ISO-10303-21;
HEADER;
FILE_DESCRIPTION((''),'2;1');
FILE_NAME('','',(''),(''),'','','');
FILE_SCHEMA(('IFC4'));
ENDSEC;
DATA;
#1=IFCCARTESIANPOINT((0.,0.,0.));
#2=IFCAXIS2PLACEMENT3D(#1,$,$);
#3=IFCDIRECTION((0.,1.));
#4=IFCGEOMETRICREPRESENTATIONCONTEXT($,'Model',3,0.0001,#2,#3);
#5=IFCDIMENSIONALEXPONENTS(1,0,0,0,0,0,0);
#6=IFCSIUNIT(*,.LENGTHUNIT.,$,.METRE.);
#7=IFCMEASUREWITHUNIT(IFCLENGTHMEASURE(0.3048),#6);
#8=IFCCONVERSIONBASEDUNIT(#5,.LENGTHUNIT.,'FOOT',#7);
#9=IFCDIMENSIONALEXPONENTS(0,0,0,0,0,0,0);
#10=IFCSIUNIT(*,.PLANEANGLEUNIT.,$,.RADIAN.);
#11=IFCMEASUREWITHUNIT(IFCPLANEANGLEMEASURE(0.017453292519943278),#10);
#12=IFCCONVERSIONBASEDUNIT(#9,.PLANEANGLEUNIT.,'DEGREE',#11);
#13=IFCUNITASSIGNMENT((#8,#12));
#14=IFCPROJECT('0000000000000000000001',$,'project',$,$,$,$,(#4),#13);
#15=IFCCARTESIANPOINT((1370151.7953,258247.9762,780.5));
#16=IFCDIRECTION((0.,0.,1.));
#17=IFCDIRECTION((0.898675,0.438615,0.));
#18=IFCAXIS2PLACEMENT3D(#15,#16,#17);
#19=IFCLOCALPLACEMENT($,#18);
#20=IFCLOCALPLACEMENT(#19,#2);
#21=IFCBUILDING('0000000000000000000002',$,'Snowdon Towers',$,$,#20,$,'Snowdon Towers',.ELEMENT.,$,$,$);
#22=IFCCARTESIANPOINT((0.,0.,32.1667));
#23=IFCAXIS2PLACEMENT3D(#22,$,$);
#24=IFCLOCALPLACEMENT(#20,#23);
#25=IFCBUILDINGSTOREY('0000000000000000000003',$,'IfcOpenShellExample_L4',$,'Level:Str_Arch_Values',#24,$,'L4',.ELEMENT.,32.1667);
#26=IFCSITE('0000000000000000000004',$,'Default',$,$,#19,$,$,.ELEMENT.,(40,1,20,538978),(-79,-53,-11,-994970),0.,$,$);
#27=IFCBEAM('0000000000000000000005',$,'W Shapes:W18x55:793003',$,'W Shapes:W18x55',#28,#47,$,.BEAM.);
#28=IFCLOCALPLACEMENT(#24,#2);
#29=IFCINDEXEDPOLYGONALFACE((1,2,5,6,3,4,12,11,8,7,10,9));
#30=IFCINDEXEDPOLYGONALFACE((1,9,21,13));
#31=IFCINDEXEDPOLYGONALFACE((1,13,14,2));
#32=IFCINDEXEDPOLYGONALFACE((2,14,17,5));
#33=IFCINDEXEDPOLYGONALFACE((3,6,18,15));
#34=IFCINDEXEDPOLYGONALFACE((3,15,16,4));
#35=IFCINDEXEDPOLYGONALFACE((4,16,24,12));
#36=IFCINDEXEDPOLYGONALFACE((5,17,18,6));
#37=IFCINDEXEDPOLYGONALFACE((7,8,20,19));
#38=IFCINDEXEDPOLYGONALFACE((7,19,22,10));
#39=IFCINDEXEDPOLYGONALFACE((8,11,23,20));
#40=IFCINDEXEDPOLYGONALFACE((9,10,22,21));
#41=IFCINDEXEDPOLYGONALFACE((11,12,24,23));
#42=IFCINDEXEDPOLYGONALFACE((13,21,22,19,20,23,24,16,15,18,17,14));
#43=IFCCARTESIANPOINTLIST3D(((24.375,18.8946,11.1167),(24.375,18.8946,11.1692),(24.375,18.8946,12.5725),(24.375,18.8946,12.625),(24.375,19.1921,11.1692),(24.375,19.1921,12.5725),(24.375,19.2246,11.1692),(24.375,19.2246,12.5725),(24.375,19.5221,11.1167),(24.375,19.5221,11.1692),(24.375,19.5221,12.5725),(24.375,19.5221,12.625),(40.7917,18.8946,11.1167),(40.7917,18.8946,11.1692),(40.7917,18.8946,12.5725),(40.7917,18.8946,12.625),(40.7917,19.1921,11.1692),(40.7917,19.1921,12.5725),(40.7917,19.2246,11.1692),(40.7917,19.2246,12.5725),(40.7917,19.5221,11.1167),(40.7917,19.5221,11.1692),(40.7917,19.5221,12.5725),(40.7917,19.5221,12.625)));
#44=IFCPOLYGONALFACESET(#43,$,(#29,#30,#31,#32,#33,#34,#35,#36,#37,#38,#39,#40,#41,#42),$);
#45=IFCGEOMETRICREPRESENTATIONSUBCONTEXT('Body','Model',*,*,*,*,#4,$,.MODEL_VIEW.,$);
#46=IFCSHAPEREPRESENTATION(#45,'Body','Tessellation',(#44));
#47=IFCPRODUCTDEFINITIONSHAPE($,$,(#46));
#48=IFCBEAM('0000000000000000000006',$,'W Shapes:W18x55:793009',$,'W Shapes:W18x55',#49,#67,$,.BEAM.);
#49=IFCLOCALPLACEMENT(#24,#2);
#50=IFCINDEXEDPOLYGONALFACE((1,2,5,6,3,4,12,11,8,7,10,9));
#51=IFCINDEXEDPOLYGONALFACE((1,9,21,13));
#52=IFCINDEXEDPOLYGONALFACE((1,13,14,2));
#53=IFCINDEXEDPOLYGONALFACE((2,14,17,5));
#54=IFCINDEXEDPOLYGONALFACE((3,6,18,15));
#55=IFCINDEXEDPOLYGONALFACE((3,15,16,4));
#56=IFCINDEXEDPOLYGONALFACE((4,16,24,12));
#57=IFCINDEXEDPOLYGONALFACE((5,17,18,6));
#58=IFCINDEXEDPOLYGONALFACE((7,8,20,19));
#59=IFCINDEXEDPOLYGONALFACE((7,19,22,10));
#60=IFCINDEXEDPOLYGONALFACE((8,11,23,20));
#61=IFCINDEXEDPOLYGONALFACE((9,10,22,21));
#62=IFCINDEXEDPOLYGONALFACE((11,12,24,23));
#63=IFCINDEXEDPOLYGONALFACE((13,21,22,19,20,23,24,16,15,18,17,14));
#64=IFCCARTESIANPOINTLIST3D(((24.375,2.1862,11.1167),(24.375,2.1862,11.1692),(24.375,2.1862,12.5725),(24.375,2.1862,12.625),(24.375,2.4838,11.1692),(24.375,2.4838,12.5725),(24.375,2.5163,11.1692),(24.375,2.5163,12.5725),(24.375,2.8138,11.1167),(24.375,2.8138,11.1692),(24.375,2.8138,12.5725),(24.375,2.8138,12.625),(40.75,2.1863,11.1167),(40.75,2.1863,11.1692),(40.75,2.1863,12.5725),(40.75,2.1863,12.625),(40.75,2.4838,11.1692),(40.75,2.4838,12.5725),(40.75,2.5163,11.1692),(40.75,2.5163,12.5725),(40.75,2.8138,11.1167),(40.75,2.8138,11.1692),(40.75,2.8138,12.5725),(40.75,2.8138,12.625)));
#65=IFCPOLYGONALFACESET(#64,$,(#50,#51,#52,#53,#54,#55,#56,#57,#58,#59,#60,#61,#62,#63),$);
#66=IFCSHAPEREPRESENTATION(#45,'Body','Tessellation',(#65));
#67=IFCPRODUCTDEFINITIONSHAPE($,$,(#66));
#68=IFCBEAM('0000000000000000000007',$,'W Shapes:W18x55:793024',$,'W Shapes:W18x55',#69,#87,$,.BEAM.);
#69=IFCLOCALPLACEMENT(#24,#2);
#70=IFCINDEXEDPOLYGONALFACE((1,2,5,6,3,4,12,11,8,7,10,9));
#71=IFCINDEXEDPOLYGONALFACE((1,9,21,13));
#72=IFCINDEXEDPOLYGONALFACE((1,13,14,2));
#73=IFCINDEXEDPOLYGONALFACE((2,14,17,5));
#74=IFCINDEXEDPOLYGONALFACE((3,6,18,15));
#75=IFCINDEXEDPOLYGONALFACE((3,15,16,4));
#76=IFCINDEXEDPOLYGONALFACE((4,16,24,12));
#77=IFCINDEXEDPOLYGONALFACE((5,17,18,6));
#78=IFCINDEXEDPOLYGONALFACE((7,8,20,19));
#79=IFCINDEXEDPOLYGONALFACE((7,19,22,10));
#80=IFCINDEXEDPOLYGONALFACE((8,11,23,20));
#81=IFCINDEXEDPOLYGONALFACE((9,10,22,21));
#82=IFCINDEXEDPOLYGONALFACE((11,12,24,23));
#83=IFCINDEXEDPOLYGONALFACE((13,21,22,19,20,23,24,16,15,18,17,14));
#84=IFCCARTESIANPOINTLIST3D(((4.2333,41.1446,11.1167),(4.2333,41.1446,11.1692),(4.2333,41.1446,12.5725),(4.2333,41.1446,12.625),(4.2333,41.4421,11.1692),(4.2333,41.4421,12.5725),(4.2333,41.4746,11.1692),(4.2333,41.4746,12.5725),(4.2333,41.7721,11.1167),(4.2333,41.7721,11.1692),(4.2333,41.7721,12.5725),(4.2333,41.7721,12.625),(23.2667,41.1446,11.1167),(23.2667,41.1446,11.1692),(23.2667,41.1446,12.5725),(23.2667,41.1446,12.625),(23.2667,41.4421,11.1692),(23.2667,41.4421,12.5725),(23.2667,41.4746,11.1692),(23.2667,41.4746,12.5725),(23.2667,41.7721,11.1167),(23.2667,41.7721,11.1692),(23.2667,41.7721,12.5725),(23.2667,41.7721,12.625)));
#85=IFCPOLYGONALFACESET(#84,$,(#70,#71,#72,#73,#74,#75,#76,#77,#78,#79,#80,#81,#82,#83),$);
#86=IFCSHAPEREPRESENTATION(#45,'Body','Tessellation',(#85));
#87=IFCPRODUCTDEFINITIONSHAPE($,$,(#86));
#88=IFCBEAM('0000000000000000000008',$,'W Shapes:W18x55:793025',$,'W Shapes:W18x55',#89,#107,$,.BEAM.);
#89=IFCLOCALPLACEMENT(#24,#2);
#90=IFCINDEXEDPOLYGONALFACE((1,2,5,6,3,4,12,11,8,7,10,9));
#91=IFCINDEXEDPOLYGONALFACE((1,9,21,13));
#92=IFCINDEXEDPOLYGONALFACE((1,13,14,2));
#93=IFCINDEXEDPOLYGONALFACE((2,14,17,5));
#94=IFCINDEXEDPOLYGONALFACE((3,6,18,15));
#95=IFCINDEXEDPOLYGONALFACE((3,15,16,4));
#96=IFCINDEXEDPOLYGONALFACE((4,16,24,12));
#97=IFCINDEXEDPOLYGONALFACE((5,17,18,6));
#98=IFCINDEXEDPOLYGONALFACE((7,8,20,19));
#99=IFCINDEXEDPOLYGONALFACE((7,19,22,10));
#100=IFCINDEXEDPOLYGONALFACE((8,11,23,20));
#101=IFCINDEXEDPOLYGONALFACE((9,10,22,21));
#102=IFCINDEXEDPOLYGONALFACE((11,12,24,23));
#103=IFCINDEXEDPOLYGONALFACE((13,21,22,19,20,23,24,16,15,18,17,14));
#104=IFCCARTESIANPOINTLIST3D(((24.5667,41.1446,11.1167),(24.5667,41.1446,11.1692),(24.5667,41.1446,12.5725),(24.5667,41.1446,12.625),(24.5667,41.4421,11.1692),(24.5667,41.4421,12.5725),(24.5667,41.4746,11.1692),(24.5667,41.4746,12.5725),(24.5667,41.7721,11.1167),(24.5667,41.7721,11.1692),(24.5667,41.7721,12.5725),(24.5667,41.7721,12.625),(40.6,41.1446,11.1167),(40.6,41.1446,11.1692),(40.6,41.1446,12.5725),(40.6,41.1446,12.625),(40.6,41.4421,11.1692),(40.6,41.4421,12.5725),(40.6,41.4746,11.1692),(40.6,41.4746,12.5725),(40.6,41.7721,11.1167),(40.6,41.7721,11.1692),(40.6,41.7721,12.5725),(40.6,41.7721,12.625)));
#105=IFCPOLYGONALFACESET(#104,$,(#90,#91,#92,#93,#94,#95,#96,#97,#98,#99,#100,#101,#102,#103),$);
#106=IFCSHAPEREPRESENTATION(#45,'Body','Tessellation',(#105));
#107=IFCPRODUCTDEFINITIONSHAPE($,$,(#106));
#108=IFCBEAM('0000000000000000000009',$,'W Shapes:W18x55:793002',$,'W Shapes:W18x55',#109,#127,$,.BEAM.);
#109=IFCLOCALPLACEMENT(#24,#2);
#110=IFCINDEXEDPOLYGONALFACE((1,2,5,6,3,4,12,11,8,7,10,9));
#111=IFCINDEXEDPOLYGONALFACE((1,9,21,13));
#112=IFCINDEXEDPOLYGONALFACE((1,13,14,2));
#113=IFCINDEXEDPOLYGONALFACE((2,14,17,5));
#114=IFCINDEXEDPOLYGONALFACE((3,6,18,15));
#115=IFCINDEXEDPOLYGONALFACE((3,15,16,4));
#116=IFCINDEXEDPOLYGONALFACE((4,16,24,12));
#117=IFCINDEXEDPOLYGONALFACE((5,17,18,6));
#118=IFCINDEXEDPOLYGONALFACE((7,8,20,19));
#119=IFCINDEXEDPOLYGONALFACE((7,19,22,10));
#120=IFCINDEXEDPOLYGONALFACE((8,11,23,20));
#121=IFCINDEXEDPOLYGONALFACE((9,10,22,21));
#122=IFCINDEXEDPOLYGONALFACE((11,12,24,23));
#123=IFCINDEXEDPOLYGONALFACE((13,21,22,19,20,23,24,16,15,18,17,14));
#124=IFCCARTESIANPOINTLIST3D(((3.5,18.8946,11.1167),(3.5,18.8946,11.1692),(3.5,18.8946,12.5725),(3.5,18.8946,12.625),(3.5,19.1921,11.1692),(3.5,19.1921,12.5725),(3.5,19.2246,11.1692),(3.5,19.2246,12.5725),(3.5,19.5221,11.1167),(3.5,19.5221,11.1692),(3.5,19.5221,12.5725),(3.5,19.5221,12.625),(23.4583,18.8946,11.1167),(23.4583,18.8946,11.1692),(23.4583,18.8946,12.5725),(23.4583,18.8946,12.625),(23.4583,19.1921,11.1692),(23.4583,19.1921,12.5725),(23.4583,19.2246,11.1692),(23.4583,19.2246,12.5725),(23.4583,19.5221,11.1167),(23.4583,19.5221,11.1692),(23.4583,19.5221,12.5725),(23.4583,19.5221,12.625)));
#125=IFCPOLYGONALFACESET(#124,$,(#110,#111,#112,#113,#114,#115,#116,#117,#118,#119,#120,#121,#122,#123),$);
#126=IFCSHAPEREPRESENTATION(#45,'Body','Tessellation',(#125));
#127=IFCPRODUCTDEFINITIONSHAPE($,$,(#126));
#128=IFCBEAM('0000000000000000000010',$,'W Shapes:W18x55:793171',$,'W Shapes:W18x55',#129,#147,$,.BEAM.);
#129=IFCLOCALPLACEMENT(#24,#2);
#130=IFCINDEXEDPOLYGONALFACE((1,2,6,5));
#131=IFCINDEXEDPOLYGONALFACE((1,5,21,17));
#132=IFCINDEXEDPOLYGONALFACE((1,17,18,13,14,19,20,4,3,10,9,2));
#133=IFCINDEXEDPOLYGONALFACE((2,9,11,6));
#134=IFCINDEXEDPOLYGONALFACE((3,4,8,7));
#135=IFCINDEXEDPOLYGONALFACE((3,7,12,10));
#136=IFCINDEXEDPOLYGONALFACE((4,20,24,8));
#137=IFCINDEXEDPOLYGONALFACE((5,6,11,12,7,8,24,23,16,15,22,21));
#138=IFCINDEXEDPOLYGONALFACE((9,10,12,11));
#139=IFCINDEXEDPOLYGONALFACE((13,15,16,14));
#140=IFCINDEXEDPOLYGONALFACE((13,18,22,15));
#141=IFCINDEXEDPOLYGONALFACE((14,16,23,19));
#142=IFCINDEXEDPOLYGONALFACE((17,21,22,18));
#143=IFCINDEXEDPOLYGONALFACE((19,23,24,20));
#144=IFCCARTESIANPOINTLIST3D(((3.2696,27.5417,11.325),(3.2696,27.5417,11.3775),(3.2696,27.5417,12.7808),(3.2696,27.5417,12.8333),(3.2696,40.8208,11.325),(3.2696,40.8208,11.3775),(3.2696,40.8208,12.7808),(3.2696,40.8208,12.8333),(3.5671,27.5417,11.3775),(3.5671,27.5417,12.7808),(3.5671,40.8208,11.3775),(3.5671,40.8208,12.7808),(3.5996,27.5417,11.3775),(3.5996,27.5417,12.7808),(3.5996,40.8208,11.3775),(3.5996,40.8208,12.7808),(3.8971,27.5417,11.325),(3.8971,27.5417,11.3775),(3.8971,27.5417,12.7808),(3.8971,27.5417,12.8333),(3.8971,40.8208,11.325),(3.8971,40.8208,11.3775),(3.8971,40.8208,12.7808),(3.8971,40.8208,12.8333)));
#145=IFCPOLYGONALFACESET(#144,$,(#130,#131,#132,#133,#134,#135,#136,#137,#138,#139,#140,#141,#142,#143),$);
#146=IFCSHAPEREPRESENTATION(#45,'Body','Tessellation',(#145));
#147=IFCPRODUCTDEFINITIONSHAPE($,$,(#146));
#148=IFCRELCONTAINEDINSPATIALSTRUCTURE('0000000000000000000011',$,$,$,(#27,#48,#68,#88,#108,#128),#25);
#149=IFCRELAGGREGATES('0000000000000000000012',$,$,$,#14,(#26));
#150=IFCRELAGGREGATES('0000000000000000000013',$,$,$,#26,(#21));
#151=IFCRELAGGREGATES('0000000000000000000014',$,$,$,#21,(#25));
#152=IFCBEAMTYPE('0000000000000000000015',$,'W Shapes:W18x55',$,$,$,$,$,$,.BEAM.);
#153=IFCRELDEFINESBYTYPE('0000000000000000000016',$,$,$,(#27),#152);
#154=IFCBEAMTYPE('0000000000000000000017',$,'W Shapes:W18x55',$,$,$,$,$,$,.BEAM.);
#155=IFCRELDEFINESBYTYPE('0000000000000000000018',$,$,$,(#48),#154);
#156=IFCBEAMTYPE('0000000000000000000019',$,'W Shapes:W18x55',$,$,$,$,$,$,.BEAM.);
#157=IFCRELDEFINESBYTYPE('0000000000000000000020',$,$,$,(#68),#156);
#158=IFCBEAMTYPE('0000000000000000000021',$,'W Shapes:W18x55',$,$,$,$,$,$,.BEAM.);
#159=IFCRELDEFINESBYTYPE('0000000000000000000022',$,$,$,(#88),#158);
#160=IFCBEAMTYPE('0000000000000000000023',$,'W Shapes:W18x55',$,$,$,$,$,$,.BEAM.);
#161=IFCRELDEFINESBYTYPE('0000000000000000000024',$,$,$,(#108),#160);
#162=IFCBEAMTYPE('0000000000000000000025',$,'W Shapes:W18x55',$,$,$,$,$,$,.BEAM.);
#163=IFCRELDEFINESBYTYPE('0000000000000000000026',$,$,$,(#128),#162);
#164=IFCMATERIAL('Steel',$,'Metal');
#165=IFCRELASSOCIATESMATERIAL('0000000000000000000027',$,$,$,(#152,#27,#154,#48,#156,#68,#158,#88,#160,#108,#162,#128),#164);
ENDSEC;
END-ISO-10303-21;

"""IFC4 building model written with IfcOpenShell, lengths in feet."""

from ifc_helpers import new_model, entity, si_unit, converted_unit, direction, frame, origin, place, context, subcontext, project, spatial, indexed_curve, outline, extrude, source, transform, mapped, material, type_object, type_shapes, element, save


model = new_model("IFC4")

# Units and contexts
model_context = context("Model", 3, precision=0.0001, world=origin(), true_north=direction((0.0, 1.0)))
body_context = subcontext(model_context, "Body", "Model", "MODEL_VIEW")
ifc_project = project(units=[converted_unit("LENGTHUNIT", "FOOT", entity("IfcLengthMeasure", 0.3048), si_unit("LENGTHUNIT", "METRE"), dimensions=[1, 0, 0, 0, 0, 0, 0]), converted_unit("PLANEANGLEUNIT", "DEGREE", entity("IfcPlaneAngleMeasure", 0.017453292519943278), si_unit("PLANEANGLEUNIT", "RADIAN"), dimensions=[0, 0, 0, 0, 0, 0, 0])], contexts=[model_context])

# Site, building, storey
site_placement = place(None, frame((1370151.7953, 258247.9762, 780.5), z_axis=(0.0, 0.0, 1.0), x_axis=(0.898675, 0.438615, 0.0)))
site = spatial("IfcSite", under=ifc_project, at=site_placement, Name="Default", CompositionType="ELEMENT", RefLatitude=(40, 1, 20, 538978), RefLongitude=(-79, -53, -11, -994970), RefElevation=0.0)
building_placement = place(site_placement, origin())
building = spatial("IfcBuilding", under=site, at=building_placement, Name="Snowdon Towers", LongName="Snowdon Towers", CompositionType="ELEMENT")
storey_placement = place(building_placement, frame((0.0, 0.0, 32.1667)))
storey = spatial("IfcBuildingStorey", under=building, at=storey_placement, Name="IfcOpenShellExample_L4", ObjectType="Level:Str_Arch_Values", LongName="L4", CompositionType="ELEMENT", Elevation=32.1667)

# Shared definitions
ifc_material = material(Name="Steel", Category="Metal")

# Beams
beam_type_1 = type_object("IfcBeamType", Name="W Shapes:W18x55", PredefinedType="BEAM", material=ifc_material)
shared_shape_1 = source(origin(), body_context, "Body", "SweptSolid", [
    extrude(outline(indexed_curve([(-0.3138, -0.7017), (-0.3138, -0.7542), (0.3138, -0.7542), (0.3138, -0.7017), (0.0162, -0.7017), (0.0162, 0.7017), (0.3138, 0.7017), (0.3138, 0.7542), (-0.3137, 0.7542), (-0.3137, 0.7017), (-0.0163, 0.7017), (-0.0163, -0.7017), (-0.3138, -0.7017)], self_intersect=False)), frame((-8.2083, 0.0, 0.0), z_axis=(-1.0, 0.0, 0.0), x_axis=(0.0, -1.0, 0.0)), (0.0, 0.0, -1.0), 16.4167),
])
type_shapes(beam_type_1, [shared_shape_1])
beam_1_placement = place(storey_placement, frame((32.5833, 19.2083, 11.8708)))
element("IfcBeam", 1, at=beam_1_placement, inside=storey, type_object=beam_type_1, material=ifc_material, Name="W Shapes:W18x55:793003", ObjectType="W Shapes:W18x55", PredefinedType="BEAM", context=body_context, shape_type="MappedRepresentation", body=[
    mapped(shared_shape_1, transform((0.0, 0.0, 0.0), scale=1.0)),
])
beam_type_2 = type_object("IfcBeamType", Name="W Shapes:W18x55", PredefinedType="BEAM", material=ifc_material)
shared_shape_2 = source(origin(), body_context, "Body", "SweptSolid", [
    extrude(outline(indexed_curve([(-0.3138, -0.7017), (-0.3138, -0.7542), (0.3138, -0.7542), (0.3138, -0.7017), (0.0162, -0.7017), (0.0162, 0.7017), (0.3138, 0.7017), (0.3138, 0.7542), (-0.3137, 0.7542), (-0.3137, 0.7017), (-0.0163, 0.7017), (-0.0163, -0.7017), (-0.3138, -0.7017)], self_intersect=False)), frame((-7.9583, 0.0, 0.0), z_axis=(-1.0, 0.0, 0.0), x_axis=(0.0, -1.0, 0.0)), (0.0, 0.0, -1.0), 16.375),
])
type_shapes(beam_type_2, [shared_shape_2])
beam_2_placement = place(storey_placement, frame((32.3333, 2.5, 11.8708)))
element("IfcBeam", 2, at=beam_2_placement, inside=storey, type_object=beam_type_2, material=ifc_material, Name="W Shapes:W18x55:793009", ObjectType="W Shapes:W18x55", PredefinedType="BEAM", context=body_context, shape_type="MappedRepresentation", body=[
    mapped(shared_shape_2, transform((0.0, 0.0, 0.0), scale=1.0)),
])
beam_type_3 = type_object("IfcBeamType", Name="W Shapes:W18x55", PredefinedType="BEAM", material=ifc_material)
shared_shape_3 = source(origin(), body_context, "Body", "SweptSolid", [
    extrude(outline(indexed_curve([(-0.3138, -0.7017), (-0.3138, -0.7542), (0.3138, -0.7542), (0.3138, -0.7017), (0.0162, -0.7017), (0.0162, 0.7017), (0.3138, 0.7017), (0.3138, 0.7542), (-0.3137, 0.7542), (-0.3137, 0.7017), (-0.0163, 0.7017), (-0.0163, -0.7017), (-0.3138, -0.7017)], self_intersect=False)), frame((-9.6, 0.0, 0.0), z_axis=(-1.0, 0.0, 0.0), x_axis=(0.0, -1.0, 0.0)), (0.0, 0.0, -1.0), 19.0333),
])
type_shapes(beam_type_3, [shared_shape_3])
beam_3_placement = place(storey_placement, frame((13.8333, 41.4583, 11.8708)))
element("IfcBeam", 3, at=beam_3_placement, inside=storey, type_object=beam_type_3, material=ifc_material, Name="W Shapes:W18x55:793024", ObjectType="W Shapes:W18x55", PredefinedType="BEAM", context=body_context, shape_type="MappedRepresentation", body=[
    mapped(shared_shape_3, transform((0.0, 0.0, 0.0), scale=1.0)),
])
beam_type_4 = type_object("IfcBeamType", Name="W Shapes:W18x55", PredefinedType="BEAM", material=ifc_material)
shared_shape_4 = source(origin(), body_context, "Body", "SweptSolid", [
    extrude(outline(indexed_curve([(-0.3138, -0.7017), (-0.3138, -0.7542), (0.3138, -0.7542), (0.3138, -0.7017), (0.0162, -0.7017), (0.0162, 0.7017), (0.3138, 0.7017), (0.3138, 0.7542), (-0.3137, 0.7542), (-0.3137, 0.7017), (-0.0163, 0.7017), (-0.0163, -0.7017), (-0.3138, -0.7017)], self_intersect=False)), frame((-8.0167, 0.0, 0.0), z_axis=(-1.0, 0.0, 0.0), x_axis=(0.0, -1.0, 0.0)), (0.0, 0.0, -1.0), 16.0333),
])
type_shapes(beam_type_4, [shared_shape_4])
beam_4_placement = place(storey_placement, frame((32.5833, 41.4583, 11.8708)))
element("IfcBeam", 4, at=beam_4_placement, inside=storey, type_object=beam_type_4, material=ifc_material, Name="W Shapes:W18x55:793025", ObjectType="W Shapes:W18x55", PredefinedType="BEAM", context=body_context, shape_type="MappedRepresentation", body=[
    mapped(shared_shape_4, transform((0.0, 0.0, 0.0), scale=1.0)),
])

# Beams
beam_type_5 = type_object("IfcBeamType", Name="W Shapes:W18x55", PredefinedType="BEAM", material=ifc_material)
shared_shape_5 = source(origin(), body_context, "Body", "SweptSolid", [
    extrude(outline(indexed_curve([(-0.3138, -0.7017), (-0.3138, -0.7542), (0.3138, -0.7542), (0.3138, -0.7017), (0.0162, -0.7017), (0.0162, 0.7017), (0.3138, 0.7017), (0.3138, 0.7542), (-0.3137, 0.7542), (-0.3137, 0.7017), (-0.0163, 0.7017), (-0.0163, -0.7017), (-0.3138, -0.7017)], self_intersect=False)), frame((-10.2083, 0.0, 0.0), z_axis=(-1.0, 0.0, 0.0), x_axis=(0.0, -1.0, 0.0)), (0.0, 0.0, -1.0), 19.9583),
])
type_shapes(beam_type_5, [shared_shape_5])
beam_5_placement = place(storey_placement, frame((13.7083, 19.2083, 11.8708)))
element("IfcBeam", 5, at=beam_5_placement, inside=storey, type_object=beam_type_5, material=ifc_material, Name="W Shapes:W18x55:793002", ObjectType="W Shapes:W18x55", PredefinedType="BEAM", context=body_context, shape_type="MappedRepresentation", body=[
    mapped(shared_shape_5, transform((0.0, 0.0, 0.0), scale=1.0)),
])
beam_type_6 = type_object("IfcBeamType", Name="W Shapes:W18x55", PredefinedType="BEAM", material=ifc_material)
shared_shape_6 = source(origin(), body_context, "Body", "SweptSolid", [
    extrude(outline(indexed_curve([(-0.3138, -0.7017), (-0.3138, -0.7542), (0.3138, -0.7542), (0.3138, -0.7017), (0.0162, -0.7017), (0.0162, 0.7017), (0.3138, 0.7017), (0.3138, 0.7542), (-0.3137, 0.7542), (-0.3137, 0.7017), (-0.0163, 0.7017), (-0.0163, -0.7017), (-0.3138, -0.7017)], self_intersect=False)), frame((-6.2375, 0.0, 0.0), z_axis=(-1.0, 0.0, 0.0), x_axis=(0.0, -1.0, 0.0)), (0.0, 0.0, -1.0), 13.2792),
])
type_shapes(beam_type_6, [shared_shape_6])
beam_6_placement = place(storey_placement, frame((3.5833, 34.5833, 12.0792), z_axis=(0.0, 0.0, 1.0), x_axis=(0.0, -1.0, 0.0)))
element("IfcBeam", 6, at=beam_6_placement, inside=storey, type_object=beam_type_6, material=ifc_material, Name="W Shapes:W18x55:793171", ObjectType="W Shapes:W18x55", PredefinedType="BEAM", context=body_context, shape_type="MappedRepresentation", body=[
    mapped(shared_shape_6, transform((0.0, 0.0, 0.0), scale=1.0)),
])

save(model, "model.ifc")
